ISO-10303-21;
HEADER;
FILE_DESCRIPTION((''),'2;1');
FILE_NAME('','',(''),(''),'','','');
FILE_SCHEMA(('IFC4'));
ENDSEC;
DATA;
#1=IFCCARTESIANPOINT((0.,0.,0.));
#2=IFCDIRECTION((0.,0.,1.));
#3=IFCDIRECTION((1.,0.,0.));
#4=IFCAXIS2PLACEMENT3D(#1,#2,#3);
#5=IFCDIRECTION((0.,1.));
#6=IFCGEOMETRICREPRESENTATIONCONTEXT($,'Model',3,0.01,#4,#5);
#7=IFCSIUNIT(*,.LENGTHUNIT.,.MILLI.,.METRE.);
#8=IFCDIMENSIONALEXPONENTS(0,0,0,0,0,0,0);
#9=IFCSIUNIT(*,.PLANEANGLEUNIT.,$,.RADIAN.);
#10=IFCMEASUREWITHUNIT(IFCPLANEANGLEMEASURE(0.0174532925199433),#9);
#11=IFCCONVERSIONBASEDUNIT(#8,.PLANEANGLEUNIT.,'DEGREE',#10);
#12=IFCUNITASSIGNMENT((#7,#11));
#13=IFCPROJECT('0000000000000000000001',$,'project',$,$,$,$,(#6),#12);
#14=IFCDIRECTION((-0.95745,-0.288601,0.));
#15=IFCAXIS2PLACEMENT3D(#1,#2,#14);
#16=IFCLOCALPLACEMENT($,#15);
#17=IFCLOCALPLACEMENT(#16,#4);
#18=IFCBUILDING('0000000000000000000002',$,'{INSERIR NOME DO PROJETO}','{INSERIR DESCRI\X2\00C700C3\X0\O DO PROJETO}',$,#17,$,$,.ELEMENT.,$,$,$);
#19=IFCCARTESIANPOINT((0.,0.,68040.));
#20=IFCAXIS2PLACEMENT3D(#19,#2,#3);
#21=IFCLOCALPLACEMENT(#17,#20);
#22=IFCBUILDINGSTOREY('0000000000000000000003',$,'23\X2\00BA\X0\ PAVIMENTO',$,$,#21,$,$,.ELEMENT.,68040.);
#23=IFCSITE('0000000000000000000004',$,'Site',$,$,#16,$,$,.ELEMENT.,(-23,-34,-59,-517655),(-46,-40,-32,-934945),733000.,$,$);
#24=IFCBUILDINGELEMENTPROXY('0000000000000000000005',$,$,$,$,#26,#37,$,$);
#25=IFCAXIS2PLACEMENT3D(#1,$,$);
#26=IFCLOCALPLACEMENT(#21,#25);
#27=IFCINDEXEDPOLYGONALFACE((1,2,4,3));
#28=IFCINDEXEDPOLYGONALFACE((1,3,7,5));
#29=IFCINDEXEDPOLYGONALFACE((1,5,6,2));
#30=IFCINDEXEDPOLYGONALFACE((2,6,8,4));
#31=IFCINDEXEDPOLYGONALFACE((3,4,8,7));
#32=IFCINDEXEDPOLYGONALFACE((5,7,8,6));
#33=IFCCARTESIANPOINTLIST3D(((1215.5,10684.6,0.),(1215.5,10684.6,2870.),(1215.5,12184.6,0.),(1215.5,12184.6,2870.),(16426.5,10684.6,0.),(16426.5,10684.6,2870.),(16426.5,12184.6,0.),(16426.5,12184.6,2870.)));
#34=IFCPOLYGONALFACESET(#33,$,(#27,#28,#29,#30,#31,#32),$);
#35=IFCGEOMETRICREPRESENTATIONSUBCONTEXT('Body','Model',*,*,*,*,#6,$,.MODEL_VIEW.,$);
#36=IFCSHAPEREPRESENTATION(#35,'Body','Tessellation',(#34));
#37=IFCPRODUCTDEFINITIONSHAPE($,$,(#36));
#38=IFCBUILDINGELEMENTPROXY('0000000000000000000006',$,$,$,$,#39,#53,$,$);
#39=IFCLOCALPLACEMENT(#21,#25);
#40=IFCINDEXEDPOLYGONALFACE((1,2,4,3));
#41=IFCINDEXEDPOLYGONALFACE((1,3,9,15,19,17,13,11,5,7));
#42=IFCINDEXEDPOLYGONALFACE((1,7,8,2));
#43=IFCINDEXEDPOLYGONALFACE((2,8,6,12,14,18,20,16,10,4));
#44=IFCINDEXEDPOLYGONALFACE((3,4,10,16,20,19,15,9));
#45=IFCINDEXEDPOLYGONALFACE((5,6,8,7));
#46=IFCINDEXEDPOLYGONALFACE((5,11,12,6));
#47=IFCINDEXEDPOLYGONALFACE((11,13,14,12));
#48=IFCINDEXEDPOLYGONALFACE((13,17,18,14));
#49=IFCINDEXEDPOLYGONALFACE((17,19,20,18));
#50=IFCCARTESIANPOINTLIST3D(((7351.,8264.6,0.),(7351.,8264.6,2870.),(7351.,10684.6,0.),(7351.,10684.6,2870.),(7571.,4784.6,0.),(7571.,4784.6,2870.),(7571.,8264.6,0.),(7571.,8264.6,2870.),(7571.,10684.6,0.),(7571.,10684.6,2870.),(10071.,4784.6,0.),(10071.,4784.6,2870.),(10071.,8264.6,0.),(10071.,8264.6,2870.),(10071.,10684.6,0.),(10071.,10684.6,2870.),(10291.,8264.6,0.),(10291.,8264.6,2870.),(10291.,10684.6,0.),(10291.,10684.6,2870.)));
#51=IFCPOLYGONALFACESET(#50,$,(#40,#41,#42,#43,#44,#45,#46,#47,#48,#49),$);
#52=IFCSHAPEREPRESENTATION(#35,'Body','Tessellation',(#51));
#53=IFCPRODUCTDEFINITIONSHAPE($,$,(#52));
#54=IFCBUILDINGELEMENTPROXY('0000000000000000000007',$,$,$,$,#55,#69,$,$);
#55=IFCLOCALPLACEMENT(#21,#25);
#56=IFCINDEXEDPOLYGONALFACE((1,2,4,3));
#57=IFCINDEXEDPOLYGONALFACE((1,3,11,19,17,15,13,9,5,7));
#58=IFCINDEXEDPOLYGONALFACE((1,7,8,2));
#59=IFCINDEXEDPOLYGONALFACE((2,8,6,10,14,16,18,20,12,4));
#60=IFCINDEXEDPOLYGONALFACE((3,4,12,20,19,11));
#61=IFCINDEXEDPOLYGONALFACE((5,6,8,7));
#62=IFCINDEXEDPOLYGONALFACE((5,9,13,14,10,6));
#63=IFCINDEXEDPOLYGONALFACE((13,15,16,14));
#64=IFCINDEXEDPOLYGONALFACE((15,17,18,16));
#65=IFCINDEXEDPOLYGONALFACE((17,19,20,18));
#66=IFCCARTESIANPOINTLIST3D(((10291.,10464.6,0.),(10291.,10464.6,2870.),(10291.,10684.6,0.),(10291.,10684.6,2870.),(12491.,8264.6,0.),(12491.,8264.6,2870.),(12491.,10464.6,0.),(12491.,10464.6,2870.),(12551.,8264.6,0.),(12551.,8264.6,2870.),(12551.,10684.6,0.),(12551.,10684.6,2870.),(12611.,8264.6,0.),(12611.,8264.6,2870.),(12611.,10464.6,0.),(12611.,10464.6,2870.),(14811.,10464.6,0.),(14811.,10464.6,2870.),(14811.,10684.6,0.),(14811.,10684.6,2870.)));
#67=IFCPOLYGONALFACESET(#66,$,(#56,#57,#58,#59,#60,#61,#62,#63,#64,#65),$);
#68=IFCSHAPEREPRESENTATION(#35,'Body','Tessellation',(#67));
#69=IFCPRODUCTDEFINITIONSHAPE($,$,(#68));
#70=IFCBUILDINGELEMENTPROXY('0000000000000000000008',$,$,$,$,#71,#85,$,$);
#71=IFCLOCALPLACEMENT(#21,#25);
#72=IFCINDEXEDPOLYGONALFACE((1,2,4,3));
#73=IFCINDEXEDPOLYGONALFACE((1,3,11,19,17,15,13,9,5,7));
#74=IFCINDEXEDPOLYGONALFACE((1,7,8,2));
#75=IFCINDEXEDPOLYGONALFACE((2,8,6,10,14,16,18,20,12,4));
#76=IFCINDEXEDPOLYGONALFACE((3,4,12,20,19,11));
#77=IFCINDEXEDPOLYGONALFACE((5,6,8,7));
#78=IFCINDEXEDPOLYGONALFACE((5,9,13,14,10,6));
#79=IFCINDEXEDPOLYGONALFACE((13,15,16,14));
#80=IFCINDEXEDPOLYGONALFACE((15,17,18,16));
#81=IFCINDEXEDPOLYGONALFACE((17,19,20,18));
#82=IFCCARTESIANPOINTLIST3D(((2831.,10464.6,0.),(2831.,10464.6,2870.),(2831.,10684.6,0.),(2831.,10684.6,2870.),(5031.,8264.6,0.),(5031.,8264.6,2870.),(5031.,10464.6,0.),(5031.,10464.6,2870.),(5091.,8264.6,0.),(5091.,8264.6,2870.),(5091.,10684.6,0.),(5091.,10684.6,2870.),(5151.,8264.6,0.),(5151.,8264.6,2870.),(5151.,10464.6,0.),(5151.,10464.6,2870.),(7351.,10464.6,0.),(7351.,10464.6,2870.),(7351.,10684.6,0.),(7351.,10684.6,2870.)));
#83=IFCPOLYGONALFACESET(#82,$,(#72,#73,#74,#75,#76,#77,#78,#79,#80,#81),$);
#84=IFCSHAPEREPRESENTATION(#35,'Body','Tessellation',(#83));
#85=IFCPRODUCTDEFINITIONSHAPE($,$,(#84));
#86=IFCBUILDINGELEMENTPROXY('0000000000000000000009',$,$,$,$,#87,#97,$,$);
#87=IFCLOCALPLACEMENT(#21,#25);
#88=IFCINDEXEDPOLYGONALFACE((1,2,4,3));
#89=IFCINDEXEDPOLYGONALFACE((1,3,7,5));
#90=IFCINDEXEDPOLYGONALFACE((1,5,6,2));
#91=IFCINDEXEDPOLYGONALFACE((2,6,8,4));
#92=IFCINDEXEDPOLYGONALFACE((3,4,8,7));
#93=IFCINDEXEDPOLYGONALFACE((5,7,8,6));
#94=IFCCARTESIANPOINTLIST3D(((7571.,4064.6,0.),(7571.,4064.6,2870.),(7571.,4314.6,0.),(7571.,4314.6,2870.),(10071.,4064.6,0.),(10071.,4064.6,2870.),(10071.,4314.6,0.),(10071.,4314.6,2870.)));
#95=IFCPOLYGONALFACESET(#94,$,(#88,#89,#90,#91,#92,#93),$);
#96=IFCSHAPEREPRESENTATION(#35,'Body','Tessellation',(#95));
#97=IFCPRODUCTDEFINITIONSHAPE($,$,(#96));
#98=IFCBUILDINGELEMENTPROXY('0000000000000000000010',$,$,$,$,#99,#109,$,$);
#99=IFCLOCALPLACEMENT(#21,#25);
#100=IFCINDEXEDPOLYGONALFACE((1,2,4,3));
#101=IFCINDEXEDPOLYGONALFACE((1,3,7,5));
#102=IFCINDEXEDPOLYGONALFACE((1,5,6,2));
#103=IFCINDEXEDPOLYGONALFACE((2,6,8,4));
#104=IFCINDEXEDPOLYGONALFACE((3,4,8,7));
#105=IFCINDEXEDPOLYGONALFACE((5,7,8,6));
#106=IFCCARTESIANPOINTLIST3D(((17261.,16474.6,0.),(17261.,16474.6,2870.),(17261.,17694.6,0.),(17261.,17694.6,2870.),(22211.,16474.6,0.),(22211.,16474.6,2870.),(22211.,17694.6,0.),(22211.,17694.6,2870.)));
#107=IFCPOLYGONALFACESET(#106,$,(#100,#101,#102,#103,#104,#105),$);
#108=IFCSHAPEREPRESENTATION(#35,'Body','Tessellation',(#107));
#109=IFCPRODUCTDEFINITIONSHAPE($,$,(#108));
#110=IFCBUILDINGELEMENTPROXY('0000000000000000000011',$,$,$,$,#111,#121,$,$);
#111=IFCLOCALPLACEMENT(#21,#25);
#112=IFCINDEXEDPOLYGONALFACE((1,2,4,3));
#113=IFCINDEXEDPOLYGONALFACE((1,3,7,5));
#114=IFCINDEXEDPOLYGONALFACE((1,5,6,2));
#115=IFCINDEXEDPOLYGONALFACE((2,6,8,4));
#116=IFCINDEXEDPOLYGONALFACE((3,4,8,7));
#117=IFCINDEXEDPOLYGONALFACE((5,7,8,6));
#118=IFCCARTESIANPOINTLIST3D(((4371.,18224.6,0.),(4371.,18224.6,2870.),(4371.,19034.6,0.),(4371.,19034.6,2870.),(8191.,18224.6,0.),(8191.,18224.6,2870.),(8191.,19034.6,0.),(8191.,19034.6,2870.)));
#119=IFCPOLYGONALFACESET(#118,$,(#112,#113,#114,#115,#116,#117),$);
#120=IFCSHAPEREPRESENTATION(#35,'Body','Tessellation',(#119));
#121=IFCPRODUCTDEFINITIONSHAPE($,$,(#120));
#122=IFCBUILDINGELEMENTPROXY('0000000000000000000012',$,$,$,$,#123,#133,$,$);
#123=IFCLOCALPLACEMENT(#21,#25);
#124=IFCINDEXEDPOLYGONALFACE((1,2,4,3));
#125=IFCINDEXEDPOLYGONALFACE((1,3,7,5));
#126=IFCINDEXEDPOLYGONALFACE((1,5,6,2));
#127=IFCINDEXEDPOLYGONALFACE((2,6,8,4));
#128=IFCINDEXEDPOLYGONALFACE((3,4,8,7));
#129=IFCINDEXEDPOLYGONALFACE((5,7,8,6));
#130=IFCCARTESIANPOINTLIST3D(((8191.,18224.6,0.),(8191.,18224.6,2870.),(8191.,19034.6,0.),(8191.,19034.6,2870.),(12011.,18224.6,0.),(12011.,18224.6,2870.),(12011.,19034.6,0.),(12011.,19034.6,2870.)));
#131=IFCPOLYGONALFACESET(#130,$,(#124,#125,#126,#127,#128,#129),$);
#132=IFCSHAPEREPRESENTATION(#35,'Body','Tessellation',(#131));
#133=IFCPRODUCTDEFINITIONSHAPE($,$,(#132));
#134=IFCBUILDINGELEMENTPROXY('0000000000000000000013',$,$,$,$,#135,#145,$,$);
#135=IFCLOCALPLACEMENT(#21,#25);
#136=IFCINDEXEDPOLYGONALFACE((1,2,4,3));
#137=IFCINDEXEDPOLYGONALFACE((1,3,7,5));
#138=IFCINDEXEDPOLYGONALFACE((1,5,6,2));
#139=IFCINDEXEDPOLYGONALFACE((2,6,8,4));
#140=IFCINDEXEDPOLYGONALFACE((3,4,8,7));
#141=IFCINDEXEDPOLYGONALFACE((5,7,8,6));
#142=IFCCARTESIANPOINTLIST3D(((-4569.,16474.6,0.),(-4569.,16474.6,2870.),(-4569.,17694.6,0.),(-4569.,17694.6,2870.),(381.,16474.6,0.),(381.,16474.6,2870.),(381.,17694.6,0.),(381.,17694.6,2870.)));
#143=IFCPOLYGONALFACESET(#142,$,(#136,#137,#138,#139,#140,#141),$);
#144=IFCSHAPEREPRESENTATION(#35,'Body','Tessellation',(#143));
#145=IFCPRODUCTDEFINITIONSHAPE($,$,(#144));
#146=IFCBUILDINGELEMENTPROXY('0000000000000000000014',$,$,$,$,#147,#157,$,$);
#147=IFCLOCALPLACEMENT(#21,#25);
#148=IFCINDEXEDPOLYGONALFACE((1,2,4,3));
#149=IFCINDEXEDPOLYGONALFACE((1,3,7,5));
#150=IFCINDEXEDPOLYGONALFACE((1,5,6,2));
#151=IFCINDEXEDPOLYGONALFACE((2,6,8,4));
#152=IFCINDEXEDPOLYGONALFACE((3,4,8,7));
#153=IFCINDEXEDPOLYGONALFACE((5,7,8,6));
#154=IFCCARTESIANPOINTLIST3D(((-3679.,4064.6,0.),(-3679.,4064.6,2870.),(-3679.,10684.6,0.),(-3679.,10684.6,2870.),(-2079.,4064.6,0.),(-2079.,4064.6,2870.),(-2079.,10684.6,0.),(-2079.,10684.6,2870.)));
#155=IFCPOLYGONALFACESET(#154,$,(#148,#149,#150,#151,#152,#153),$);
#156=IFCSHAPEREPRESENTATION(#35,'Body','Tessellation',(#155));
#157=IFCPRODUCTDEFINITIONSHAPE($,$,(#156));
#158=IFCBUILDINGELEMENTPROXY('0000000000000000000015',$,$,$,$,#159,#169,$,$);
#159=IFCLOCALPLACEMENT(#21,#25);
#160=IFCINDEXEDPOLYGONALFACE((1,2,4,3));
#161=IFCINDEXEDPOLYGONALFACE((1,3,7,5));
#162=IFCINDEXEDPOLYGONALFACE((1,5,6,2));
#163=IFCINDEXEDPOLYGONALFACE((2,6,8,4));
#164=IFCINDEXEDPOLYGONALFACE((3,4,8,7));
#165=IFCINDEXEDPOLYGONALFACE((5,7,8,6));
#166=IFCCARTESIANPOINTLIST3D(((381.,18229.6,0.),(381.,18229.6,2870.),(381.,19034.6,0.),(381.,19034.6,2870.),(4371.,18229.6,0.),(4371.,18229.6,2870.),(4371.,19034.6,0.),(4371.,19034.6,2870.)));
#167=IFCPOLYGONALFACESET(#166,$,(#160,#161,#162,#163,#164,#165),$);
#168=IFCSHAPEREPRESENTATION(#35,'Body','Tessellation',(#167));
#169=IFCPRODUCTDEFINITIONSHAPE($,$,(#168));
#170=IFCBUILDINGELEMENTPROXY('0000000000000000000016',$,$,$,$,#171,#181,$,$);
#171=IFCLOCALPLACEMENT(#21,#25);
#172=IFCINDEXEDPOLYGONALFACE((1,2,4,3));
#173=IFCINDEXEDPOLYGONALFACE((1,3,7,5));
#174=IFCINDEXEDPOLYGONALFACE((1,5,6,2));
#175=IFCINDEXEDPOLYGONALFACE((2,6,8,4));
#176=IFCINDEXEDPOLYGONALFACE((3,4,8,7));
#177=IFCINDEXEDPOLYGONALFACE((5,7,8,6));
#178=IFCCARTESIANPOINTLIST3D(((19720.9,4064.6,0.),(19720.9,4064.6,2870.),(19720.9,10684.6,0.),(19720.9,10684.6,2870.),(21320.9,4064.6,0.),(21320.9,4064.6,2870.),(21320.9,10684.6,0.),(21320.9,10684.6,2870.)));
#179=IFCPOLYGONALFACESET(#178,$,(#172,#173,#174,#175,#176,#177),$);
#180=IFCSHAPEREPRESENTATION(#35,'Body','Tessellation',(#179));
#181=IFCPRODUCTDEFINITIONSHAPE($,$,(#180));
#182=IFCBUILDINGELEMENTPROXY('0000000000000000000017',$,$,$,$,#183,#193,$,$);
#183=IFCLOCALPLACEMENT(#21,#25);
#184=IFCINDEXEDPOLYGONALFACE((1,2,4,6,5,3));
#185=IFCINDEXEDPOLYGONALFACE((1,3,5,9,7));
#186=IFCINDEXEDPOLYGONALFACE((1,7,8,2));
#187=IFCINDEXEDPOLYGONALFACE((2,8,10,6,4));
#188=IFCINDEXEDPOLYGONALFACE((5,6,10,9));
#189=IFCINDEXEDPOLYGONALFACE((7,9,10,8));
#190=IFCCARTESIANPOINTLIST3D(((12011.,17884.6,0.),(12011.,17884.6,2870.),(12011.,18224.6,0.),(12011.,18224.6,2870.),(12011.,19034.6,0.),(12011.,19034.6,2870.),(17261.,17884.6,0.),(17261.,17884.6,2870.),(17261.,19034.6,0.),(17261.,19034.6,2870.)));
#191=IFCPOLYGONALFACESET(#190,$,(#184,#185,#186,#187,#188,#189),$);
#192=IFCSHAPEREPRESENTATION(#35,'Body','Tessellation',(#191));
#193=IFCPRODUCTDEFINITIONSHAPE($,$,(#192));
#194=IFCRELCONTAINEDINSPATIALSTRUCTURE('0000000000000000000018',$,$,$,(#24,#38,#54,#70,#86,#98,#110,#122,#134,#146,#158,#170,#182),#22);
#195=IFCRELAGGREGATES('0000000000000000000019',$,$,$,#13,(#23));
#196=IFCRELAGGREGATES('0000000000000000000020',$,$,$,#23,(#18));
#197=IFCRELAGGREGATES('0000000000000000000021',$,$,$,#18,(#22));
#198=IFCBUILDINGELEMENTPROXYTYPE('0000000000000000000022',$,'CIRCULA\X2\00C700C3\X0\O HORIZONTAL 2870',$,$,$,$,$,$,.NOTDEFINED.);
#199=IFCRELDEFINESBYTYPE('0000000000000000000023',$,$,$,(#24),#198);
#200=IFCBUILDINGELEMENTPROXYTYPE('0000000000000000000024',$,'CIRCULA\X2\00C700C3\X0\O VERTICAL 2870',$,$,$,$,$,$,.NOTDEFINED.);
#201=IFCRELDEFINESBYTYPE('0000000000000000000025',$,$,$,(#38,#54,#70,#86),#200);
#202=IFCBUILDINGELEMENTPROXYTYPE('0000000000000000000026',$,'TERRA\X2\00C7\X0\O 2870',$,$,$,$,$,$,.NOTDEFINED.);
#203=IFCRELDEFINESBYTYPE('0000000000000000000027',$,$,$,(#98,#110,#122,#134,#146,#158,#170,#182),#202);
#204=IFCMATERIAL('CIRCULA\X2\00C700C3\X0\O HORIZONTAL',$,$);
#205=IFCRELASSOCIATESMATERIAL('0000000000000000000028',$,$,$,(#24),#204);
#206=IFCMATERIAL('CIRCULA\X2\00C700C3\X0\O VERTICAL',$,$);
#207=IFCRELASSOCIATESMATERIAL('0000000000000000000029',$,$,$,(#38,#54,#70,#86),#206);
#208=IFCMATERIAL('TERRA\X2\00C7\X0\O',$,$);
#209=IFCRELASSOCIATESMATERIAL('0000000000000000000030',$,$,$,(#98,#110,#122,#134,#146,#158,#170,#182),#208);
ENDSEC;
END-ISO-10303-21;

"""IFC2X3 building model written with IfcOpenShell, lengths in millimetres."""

from ifc_helpers import new_model, entity, si_unit, converted_unit, direction, frame, origin_with_axes, place, context, subcontext, project, spatial, polyline, outline, extrude, material, type_object, element, save


model = new_model("IFC2X3")

# Units and contexts
model_context = context("Model", 3, precision=0.01, world=origin_with_axes(), true_north=direction((0.0, 1.0)))
body_context = subcontext(model_context, "Body", "Model", "MODEL_VIEW")
ifc_project = project(units=[si_unit("LENGTHUNIT", "METRE", prefix="MILLI"), converted_unit("PLANEANGLEUNIT", "DEGREE", entity("IfcPlaneAngleMeasure", 0.0174532925199433), si_unit("PLANEANGLEUNIT", "RADIAN"), dimensions=[0, 0, 0, 0, 0, 0, 0])], contexts=[model_context])

# Site, building, storey
site_placement = place(None, frame((0.0, 0.0, 0.0), z_axis=(0.0, 0.0, 1.0), x_axis=(-0.95745, -0.288601, 0.0)))
site = spatial("IfcSite", under=ifc_project, at=site_placement, Name="Site", CompositionType="ELEMENT", RefLatitude=(-23, -34, -59, -517655), RefLongitude=(-46, -40, -32, -934945), RefElevation=733000.0)
building_placement = place(site_placement, origin_with_axes())
building = spatial("IfcBuilding", under=site, at=building_placement, Name="{INSERIR NOME DO PROJETO}", Description="{INSERIR DESCRIÇÃO DO PROJETO}", CompositionType="ELEMENT")
storey_placement = place(building_placement, frame((0.0, 0.0, 68040.0), z_axis=(0.0, 0.0, 1.0), x_axis=(1.0, 0.0, 0.0)))
storey = spatial("IfcBuildingStorey", under=building, at=storey_placement, Name="23º PAVIMENTO", CompositionType="ELEMENT", Elevation=68040.0)

# Building element proxies
ifc_material_1 = material(Name="CIRCULAÇÃO HORIZONTAL")
building_element_proxy_type_1 = type_object("IfcBuildingElementProxyType", Name="CIRCULAÇÃO HORIZONTAL 2870", PredefinedType="NOTDEFINED")
proxy_1_placement = place(storey_placement, frame((1215.5, 10684.6, 0.0), z_axis=(0.0, 0.0, 1.0), x_axis=(1.0, 0.0, 0.0)))
element("IfcBuildingElementProxy", 1, at=proxy_1_placement, inside=storey, type_object=building_element_proxy_type_1, material=ifc_material_1, context=body_context, shape_type="SweptSolid", body=[
    extrude(outline(polyline([(0.0, 0.0), (15211.0, 0.0), (15211.0, 1500.0), (0.0, 1500.0), (0.0, 0.0)])), origin_with_axes(), (0.0, 0.0, 1.0), 2870.0),
])
ifc_material_2 = material(Name="CIRCULAÇÃO VERTICAL")
building_element_proxy_type_2 = type_object("IfcBuildingElementProxyType", Name="CIRCULAÇÃO VERTICAL 2870", PredefinedType="NOTDEFINED")
proxy_2_placement = place(storey_placement, frame((7351.0, 10684.6, 0.0), z_axis=(0.0, 0.0, 1.0), x_axis=(1.0, 0.0, 0.0)))
element("IfcBuildingElementProxy", 2, at=proxy_2_placement, inside=storey, type_object=building_element_proxy_type_2, material=ifc_material_2, context=body_context, shape_type="SweptSolid", body=[
    extrude(outline(polyline([(0.0, 0.0), (0.0, -2420.0), (220.0, -2420.0), (220.0, -5900.0), (2720.0, -5900.0), (2720.0, -2420.0), (2940.0, -2420.0), (2940.0, 0.0), (2720.0, 0.0), (220.0, 0.0), (0.0, 0.0)])), origin_with_axes(), (0.0, 0.0, 1.0), 2870.0),
])
proxy_3_placement = place(storey_placement, frame((10291.0, 10684.6, 0.0), z_axis=(0.0, 0.0, 1.0), x_axis=(1.0, 0.0, 0.0)))
element("IfcBuildingElementProxy", 3, at=proxy_3_placement, inside=storey, type_object=building_element_proxy_type_2, material=ifc_material_2, context=body_context, shape_type="SweptSolid", body=[
    extrude(outline(polyline([(0.0, 0.0), (0.0, -220.0), (2200.0, -220.0), (2200.0, -2420.0), (2260.0, -2420.0), (2320.0, -2420.0), (2320.0, -220.0), (4520.0, -220.0), (4520.0, 0.0), (2260.0, 0.0), (0.0, 0.0)])), origin_with_axes(), (0.0, 0.0, 1.0), 2870.0),
])
proxy_4_placement = place(storey_placement, frame((5091.0, 10684.6, 0.0), z_axis=(0.0, 0.0, 1.0), x_axis=(1.0, 0.0, 0.0)))
element("IfcBuildingElementProxy", 4, at=proxy_4_placement, inside=storey, type_object=building_element_proxy_type_2, material=ifc_material_2, context=body_context, shape_type="SweptSolid", body=[
    extrude(outline(polyline([(0.0, 0.0), (-2260.0, 0.0), (-2260.0, -220.0), (-60.0, -220.0), (-60.0, -2420.0), (0.0, -2420.0), (60.0, -2420.0), (60.0, -220.0), (2260.0, -220.0), (2260.0, 0.0), (0.0, 0.0)])), origin_with_axes(), (0.0, 0.0, 1.0), 2870.0),
])
proxy_5_placement = place(storey_placement, frame((7571.0, 4064.6, 0.0), z_axis=(0.0, 0.0, 1.0), x_axis=(1.0, 0.0, 0.0)))
element("IfcBuildingElementProxy", 5, at=proxy_5_placement, inside=storey, type_object=building_element_proxy_type_2, material=ifc_material_2, context=body_context, shape_type="SweptSolid", body=[
    extrude(outline(polyline([(0.0, 0.0), (2500.0, 0.0), (2500.0, 250.0), (0.0, 250.0), (0.0, 0.0)])), origin_with_axes(), (0.0, 0.0, 1.0), 2870.0),
])
ifc_material_3 = material(Name="TERRAÇO")
building_element_proxy_type_3 = type_object("IfcBuildingElementProxyType", Name="TERRAÇO 2870", PredefinedType="NOTDEFINED")
proxy_6_placement = place(storey_placement, frame((17261.0, 16474.6, 0.0), z_axis=(0.0, 0.0, 1.0), x_axis=(1.0, 0.0, 0.0)))
element("IfcBuildingElementProxy", 6, at=proxy_6_placement, inside=storey, type_object=building_element_proxy_type_3, material=ifc_material_3, context=body_context, shape_type="SweptSolid", body=[
    extrude(outline(polyline([(0.0, 0.0), (4950.0, 0.0), (4950.0, 1220.0), (0.0, 1220.0), (0.0, 0.0)])), origin_with_axes(), (0.0, 0.0, 1.0), 2870.0),
])
for number, where, z_axis, x_axis in (
    (7, (4371.0, 18224.6, 0.0), (0.0, 0.0, 1.0), (1.0, 0.0, 0.0)),
    (8, (8191.0, 18224.6, 0.0), (0.0, 0.0, 1.0), (1.0, 0.0, 0.0)),
):
    element("IfcBuildingElementProxy", number, at=place(storey_placement, frame(where, z_axis=z_axis, x_axis=x_axis)), inside=storey, type_object=building_element_proxy_type_3, material=ifc_material_3, context=body_context, shape_type="SweptSolid", body=[
        extrude(outline(polyline([(0.0, 0.0), (3820.0, 0.0), (3820.0, 810.0), (0.0, 810.0), (0.0, 0.0)])), origin_with_axes(), (0.0, 0.0, 1.0), 2870.0),
    ])
proxy_7_placement = place(storey_placement, frame((381.0, 17694.6, 0.0), z_axis=(0.0, 0.0, 1.0), x_axis=(1.0, 0.0, 0.0)))
element("IfcBuildingElementProxy", 9, at=proxy_7_placement, inside=storey, type_object=building_element_proxy_type_3, material=ifc_material_3, context=body_context, shape_type="SweptSolid", body=[
    extrude(outline(polyline([(0.0, 0.0), (-4950.0, 0.0), (-4950.0, -1220.0), (0.0, -1220.0), (0.0, 0.0)])), origin_with_axes(), (0.0, 0.0, 1.0), 2870.0),
])
proxy_8_placement = place(storey_placement, frame((-3679.0, 4064.6, 0.0), z_axis=(0.0, 0.0, 1.0), x_axis=(1.0, 0.0, 0.0)))
element("IfcBuildingElementProxy", 10, at=proxy_8_placement, inside=storey, type_object=building_element_proxy_type_3, material=ifc_material_3, context=body_context, shape_type="SweptSolid", body=[
    extrude(outline(polyline([(0.0, 0.0), (1600.0, 0.0), (1600.0, 6620.0), (0.0, 6620.0), (0.0, 0.0)])), origin_with_axes(), (0.0, 0.0, 1.0), 2870.0),
])
proxy_9_placement = place(storey_placement, frame((381.0, 19034.6, 0.0), z_axis=(0.0, 0.0, 1.0), x_axis=(1.0, 0.0, 0.0)))
element("IfcBuildingElementProxy", 11, at=proxy_9_placement, inside=storey, type_object=building_element_proxy_type_3, material=ifc_material_3, context=body_context, shape_type="SweptSolid", body=[
    extrude(outline(polyline([(0.0, 0.0), (0.0, -805.0), (3990.0, -805.0), (3990.0, 0.0), (0.0, 0.0)])), origin_with_axes(), (0.0, 0.0, 1.0), 2870.0),
])
proxy_10_placement = place(storey_placement, frame((21320.9, 4064.6, 0.0), z_axis=(0.0, 0.0, 1.0), x_axis=(1.0, 0.0, 0.0)))
element("IfcBuildingElementProxy", 12, at=proxy_10_placement, inside=storey, type_object=building_element_proxy_type_3, material=ifc_material_3, context=body_context, shape_type="SweptSolid", body=[
    extrude(outline(polyline([(0.0, 0.0), (0.0, 6620.0), (-1600.0, 6620.0), (-1600.0, 0.0), (0.0, 0.0)])), origin_with_axes(), (0.0, 0.0, 1.0), 2870.0),
])
proxy_11_placement = place(storey_placement, frame((12011.0, 19034.6, 0.0), z_axis=(0.0, 0.0, 1.0), x_axis=(1.0, 0.0, 0.0)))
element("IfcBuildingElementProxy", 13, at=proxy_11_placement, inside=storey, type_object=building_element_proxy_type_3, material=ifc_material_3, context=body_context, shape_type="SweptSolid", body=[
    extrude(outline(polyline([(0.0, 0.0), (0.0, -810.0), (0.0, -1150.0), (5250.0, -1150.0), (5250.0, 0.0), (0.0, 0.0)])), origin_with_axes(), (0.0, 0.0, 1.0), 2870.0),
])

save(model, "model.ifc")
